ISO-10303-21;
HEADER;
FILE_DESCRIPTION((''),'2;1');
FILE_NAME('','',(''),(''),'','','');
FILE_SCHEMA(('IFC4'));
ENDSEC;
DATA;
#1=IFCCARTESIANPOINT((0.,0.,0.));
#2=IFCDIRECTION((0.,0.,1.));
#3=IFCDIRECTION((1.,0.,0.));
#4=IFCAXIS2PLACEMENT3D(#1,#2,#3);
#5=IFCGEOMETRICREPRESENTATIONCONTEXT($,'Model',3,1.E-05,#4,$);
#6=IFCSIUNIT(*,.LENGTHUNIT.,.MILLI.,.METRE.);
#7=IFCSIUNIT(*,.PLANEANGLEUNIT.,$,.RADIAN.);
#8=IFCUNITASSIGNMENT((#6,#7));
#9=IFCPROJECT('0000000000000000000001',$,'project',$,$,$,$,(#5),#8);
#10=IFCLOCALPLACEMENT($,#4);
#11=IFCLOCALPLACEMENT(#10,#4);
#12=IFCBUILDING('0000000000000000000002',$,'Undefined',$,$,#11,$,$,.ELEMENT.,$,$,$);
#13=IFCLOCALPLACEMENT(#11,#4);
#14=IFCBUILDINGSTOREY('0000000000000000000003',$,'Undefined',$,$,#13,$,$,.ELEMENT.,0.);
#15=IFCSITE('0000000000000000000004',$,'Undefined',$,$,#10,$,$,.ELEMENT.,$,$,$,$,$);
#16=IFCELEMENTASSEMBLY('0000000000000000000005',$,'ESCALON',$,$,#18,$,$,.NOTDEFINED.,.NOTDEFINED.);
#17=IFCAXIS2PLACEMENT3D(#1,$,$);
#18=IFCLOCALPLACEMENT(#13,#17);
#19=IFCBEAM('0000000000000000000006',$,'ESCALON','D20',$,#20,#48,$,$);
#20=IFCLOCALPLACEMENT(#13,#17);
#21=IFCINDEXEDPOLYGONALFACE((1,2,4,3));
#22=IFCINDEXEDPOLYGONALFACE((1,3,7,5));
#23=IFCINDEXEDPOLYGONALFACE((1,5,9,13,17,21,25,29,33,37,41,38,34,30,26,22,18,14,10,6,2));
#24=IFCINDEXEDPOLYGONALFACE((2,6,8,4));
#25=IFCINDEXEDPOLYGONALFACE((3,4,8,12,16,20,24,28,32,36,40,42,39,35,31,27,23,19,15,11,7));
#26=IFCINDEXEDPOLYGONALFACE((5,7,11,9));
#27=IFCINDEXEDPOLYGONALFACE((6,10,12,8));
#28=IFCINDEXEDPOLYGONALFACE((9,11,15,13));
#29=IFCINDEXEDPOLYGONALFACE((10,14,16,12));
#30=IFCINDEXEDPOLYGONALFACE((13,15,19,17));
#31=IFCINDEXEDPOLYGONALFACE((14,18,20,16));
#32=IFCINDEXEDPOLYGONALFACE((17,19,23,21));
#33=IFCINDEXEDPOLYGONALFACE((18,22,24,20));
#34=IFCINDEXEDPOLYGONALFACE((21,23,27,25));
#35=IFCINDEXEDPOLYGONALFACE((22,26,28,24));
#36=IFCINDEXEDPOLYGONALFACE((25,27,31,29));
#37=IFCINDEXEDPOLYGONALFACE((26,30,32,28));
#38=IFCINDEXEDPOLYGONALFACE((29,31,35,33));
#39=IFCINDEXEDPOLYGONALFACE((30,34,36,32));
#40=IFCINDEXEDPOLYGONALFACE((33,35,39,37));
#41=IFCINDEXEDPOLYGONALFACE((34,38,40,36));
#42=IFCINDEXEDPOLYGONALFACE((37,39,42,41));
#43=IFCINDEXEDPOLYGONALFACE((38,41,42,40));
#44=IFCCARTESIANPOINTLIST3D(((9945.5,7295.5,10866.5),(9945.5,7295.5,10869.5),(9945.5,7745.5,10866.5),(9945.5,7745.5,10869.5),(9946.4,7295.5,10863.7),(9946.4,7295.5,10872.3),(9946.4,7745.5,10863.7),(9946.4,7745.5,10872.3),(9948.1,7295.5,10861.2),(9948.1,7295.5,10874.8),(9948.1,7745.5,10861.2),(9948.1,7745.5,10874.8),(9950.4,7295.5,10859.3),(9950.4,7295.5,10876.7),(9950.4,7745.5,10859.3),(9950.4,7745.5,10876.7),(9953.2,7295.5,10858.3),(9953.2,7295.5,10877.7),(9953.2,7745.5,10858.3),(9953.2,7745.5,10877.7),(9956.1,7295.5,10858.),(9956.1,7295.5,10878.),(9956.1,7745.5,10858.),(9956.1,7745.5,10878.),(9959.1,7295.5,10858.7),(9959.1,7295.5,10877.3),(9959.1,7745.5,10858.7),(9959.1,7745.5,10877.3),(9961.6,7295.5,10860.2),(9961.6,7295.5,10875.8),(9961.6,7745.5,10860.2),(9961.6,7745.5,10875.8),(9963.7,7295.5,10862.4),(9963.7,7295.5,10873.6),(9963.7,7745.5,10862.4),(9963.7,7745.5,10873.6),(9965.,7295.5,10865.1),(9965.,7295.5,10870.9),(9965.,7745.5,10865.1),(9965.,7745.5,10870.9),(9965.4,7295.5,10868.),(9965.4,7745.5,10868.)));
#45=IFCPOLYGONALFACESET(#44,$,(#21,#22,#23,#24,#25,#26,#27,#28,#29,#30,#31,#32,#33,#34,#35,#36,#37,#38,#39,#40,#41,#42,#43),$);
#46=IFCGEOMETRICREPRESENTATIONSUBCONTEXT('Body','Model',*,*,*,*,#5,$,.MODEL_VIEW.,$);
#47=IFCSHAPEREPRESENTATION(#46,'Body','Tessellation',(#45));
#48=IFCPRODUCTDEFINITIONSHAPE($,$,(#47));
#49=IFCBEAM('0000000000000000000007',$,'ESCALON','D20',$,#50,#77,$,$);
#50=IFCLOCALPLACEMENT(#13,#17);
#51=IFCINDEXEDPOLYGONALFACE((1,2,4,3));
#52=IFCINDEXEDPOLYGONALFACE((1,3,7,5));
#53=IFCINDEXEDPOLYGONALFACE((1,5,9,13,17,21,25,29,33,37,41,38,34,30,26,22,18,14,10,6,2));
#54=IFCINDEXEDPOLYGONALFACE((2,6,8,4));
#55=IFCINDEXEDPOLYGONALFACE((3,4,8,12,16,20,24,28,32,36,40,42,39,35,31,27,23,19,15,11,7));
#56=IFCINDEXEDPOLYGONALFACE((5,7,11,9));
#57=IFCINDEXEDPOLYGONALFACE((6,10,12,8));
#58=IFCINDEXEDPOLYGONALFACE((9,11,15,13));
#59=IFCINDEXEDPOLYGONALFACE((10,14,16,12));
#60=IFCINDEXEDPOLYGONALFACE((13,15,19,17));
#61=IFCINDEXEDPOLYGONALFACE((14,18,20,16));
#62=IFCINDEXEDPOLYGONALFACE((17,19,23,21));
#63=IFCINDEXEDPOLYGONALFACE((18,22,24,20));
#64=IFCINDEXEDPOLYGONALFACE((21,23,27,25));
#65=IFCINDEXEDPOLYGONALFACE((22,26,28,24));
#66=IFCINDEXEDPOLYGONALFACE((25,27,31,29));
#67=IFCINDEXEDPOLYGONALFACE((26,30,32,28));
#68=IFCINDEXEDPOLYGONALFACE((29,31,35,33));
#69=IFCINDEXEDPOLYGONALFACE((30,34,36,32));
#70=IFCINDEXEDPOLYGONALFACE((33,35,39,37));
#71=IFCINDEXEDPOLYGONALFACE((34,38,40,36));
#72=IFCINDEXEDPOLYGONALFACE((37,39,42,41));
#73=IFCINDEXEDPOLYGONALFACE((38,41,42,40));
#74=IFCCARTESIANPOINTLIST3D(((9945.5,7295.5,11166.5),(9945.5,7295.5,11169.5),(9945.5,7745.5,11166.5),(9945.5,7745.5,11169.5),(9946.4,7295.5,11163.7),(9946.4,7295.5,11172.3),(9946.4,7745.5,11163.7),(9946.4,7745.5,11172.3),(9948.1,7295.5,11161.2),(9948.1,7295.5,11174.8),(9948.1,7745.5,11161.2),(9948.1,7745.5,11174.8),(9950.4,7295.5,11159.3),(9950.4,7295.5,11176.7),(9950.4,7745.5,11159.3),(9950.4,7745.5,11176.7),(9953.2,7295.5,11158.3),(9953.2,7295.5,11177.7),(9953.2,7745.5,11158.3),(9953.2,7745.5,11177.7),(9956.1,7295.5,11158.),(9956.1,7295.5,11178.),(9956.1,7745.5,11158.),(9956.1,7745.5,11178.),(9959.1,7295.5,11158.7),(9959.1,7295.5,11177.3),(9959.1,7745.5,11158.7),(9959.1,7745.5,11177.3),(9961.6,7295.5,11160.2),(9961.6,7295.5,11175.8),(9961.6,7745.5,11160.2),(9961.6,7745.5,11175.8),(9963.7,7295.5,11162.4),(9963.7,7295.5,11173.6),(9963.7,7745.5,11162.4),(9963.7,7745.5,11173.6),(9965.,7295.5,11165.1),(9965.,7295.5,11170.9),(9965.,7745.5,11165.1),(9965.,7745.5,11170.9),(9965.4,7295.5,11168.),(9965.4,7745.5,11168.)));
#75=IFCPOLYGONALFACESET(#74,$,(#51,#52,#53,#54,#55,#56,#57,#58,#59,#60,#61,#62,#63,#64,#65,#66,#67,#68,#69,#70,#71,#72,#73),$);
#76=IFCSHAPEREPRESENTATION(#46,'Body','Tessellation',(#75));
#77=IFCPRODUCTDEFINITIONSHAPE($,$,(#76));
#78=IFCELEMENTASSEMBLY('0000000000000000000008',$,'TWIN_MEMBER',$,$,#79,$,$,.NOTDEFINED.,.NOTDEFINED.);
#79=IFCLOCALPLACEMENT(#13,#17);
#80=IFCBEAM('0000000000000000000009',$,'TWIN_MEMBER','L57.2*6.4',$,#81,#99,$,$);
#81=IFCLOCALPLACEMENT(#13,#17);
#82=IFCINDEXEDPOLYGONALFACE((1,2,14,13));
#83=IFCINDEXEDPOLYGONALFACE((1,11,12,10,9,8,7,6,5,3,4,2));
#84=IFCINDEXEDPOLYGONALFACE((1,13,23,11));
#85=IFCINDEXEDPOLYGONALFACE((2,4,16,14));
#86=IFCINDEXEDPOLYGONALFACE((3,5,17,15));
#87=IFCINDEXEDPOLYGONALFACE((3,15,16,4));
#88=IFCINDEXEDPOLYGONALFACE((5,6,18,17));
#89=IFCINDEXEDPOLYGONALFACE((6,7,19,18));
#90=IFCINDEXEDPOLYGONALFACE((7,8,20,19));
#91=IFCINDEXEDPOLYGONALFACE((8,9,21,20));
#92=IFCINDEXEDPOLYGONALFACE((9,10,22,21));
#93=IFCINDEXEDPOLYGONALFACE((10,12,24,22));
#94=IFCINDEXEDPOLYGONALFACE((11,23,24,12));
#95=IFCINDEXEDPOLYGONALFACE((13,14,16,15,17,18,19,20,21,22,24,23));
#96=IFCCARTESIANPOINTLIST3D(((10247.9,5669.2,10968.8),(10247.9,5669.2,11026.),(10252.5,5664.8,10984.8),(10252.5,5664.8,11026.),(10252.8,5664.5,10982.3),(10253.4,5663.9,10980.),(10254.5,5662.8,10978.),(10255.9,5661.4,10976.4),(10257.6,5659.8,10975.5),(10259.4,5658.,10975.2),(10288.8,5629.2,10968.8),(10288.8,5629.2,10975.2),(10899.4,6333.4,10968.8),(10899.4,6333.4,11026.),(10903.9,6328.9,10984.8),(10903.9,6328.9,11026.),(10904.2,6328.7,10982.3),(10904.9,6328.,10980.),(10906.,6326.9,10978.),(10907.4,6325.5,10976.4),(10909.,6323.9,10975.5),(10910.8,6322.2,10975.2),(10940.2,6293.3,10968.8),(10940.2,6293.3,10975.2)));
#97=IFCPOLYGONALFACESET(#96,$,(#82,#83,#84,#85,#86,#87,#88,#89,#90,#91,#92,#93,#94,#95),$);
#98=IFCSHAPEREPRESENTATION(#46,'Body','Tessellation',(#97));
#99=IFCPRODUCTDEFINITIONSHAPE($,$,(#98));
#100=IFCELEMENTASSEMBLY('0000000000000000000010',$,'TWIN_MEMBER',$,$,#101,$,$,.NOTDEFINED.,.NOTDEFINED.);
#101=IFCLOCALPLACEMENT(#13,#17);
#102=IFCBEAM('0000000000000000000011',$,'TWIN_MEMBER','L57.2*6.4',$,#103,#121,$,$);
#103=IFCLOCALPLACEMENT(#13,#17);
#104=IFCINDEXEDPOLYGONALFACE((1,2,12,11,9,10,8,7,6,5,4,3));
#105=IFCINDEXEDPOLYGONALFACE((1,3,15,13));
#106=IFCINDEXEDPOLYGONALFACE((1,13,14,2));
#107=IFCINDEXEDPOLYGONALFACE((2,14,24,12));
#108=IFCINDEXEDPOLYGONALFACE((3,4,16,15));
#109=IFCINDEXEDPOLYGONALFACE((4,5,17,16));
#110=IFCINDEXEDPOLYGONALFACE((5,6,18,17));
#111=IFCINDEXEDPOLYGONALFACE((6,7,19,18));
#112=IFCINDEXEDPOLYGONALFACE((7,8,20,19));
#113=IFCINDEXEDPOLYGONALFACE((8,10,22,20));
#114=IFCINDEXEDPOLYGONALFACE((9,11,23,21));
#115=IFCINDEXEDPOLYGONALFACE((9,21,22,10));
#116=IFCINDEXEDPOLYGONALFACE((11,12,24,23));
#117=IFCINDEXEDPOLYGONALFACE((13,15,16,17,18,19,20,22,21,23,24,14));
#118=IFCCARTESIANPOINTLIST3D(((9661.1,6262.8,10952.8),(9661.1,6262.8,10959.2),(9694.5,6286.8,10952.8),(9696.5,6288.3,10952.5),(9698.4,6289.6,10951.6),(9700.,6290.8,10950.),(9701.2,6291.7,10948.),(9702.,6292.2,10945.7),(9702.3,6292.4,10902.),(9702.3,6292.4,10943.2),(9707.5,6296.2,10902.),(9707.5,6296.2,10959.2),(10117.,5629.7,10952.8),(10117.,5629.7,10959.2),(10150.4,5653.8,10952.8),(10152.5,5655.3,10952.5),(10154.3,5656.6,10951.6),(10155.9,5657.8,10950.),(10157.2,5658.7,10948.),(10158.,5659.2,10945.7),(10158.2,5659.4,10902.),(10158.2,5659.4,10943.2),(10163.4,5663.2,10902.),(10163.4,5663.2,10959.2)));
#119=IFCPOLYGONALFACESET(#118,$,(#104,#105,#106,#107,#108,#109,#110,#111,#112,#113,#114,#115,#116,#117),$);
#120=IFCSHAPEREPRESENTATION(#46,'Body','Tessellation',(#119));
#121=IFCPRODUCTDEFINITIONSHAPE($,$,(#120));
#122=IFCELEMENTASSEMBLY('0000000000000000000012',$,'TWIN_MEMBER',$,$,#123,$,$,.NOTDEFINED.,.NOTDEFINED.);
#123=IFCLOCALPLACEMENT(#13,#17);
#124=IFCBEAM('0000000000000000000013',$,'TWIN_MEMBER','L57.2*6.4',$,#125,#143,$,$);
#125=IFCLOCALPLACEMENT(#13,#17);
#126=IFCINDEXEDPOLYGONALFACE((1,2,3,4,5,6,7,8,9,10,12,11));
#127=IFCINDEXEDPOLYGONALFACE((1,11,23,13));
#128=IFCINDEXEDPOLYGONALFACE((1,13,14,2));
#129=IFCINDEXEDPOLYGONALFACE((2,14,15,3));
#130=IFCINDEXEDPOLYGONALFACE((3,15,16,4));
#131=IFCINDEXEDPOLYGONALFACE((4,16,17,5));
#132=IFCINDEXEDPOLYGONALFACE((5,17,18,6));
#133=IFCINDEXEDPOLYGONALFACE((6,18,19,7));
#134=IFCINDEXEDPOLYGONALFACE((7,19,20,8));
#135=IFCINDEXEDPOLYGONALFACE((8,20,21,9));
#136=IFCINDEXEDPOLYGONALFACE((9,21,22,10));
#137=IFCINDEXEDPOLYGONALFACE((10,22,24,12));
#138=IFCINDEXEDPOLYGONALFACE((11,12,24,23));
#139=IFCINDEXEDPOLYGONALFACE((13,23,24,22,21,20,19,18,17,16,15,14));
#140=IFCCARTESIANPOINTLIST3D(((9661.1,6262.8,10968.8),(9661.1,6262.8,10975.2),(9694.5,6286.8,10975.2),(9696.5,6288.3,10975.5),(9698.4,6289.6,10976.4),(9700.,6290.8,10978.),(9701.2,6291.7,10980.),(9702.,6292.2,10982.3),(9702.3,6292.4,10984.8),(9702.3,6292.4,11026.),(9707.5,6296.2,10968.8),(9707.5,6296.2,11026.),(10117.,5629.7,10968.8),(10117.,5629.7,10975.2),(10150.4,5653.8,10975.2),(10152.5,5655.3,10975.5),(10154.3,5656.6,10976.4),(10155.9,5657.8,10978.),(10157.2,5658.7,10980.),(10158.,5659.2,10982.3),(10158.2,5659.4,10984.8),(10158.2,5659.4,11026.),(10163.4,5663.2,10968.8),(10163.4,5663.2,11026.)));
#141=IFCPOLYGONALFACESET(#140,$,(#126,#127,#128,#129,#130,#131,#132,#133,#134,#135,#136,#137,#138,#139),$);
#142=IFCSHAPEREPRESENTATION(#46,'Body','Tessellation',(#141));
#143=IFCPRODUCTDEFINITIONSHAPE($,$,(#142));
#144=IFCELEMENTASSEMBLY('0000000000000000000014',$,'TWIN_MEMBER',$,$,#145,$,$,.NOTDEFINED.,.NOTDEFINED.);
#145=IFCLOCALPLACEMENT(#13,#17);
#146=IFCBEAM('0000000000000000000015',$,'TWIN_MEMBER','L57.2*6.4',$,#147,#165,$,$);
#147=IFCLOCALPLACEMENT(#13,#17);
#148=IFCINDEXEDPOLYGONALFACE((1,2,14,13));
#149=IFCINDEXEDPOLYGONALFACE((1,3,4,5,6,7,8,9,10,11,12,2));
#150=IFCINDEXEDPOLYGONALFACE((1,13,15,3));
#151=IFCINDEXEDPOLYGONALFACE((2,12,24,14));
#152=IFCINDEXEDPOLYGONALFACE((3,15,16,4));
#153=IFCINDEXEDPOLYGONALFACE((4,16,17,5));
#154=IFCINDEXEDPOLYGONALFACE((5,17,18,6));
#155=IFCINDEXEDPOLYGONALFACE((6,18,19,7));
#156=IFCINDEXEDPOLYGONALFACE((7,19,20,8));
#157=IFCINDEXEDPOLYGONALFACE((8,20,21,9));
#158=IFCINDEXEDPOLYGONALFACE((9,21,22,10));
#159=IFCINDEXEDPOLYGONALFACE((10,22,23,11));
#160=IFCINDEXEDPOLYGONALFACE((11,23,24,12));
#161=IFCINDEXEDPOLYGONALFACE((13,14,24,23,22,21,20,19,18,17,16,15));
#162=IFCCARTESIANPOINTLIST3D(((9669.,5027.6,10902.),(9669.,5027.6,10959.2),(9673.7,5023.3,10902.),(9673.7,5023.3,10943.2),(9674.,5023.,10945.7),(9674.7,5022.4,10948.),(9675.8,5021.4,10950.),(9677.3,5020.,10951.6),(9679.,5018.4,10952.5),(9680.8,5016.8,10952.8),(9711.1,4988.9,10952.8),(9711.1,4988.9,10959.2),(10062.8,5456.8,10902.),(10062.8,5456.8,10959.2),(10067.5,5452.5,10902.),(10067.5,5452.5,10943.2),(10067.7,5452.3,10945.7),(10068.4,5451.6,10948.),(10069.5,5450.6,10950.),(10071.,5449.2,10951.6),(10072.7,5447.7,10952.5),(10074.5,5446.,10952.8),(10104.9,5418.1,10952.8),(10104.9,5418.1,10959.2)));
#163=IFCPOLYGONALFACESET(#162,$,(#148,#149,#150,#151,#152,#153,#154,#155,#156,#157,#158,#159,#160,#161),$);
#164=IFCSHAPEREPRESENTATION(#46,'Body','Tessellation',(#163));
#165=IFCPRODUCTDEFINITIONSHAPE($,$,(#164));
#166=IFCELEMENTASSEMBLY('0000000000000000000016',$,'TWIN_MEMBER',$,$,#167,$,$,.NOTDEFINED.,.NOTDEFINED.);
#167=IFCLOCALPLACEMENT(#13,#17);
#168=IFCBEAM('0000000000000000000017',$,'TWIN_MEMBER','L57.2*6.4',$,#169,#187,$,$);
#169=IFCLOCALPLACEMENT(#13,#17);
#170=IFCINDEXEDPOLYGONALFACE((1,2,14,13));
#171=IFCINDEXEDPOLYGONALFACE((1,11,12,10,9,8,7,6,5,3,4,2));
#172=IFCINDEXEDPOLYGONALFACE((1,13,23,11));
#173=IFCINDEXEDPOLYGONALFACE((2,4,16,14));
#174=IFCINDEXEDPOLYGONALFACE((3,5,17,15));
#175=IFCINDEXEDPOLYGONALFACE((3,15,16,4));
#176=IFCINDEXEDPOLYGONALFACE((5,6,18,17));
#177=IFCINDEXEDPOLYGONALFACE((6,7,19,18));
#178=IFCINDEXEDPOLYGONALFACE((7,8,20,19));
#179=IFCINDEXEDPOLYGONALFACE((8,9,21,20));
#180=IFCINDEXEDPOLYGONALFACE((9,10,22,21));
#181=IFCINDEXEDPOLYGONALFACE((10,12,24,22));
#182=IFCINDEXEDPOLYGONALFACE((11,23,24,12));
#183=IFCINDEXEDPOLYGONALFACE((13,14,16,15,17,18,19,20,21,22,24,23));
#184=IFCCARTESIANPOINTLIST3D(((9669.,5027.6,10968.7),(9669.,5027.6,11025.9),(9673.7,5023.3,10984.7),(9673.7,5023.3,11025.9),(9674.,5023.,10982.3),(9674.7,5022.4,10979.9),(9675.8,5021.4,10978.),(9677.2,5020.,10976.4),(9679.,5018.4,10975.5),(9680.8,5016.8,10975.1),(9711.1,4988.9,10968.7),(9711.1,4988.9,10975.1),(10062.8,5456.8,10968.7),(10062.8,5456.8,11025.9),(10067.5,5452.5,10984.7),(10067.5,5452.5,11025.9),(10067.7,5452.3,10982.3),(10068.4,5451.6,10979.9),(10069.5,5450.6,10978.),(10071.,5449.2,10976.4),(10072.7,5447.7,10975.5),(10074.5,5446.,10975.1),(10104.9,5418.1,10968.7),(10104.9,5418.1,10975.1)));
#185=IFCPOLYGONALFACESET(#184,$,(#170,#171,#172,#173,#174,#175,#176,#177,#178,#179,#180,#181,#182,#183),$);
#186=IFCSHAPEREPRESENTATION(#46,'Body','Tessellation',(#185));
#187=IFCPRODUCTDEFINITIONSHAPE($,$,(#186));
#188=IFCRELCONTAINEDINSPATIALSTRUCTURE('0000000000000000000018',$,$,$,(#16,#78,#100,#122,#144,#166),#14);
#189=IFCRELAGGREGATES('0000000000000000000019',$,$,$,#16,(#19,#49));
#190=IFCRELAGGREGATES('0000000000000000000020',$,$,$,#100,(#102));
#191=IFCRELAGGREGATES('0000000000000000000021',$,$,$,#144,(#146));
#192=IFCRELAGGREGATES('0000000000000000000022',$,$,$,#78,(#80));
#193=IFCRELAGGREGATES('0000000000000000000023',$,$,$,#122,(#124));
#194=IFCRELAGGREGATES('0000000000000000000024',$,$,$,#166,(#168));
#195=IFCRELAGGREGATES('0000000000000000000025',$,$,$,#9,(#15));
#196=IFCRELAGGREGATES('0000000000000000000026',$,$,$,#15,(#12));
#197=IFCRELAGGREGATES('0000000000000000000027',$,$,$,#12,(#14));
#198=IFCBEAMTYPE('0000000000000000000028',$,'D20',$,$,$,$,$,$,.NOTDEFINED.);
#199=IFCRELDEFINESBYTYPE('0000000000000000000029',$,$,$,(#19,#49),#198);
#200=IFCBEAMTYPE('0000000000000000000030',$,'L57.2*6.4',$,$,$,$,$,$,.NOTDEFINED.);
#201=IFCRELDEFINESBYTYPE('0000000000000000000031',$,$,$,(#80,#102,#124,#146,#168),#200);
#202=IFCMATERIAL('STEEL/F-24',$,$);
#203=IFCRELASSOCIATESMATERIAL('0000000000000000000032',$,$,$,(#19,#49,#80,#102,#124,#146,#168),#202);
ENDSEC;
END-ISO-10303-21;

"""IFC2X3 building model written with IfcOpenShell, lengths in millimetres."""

from ifc_helpers import new_model, si_unit, frame, origin_with_axes, origin_2d_with_axis, place, context, subcontext, project, spatial, circle, l_section, extrude, material, type_object, element, aggregate, save


model = new_model("IFC2X3")

# Units and contexts
model_context = context("Model", 3, precision=1e-05, world=origin_with_axes())
body_context = subcontext(model_context, "Body", "Model", "MODEL_VIEW")
ifc_project = project(units=[si_unit("LENGTHUNIT", "METRE", prefix="MILLI"), si_unit("PLANEANGLEUNIT", "RADIAN")], contexts=[model_context])

# Site, building, storey
site_placement = place(None, origin_with_axes())
site = spatial("IfcSite", under=ifc_project, at=site_placement, Name="Undefined", CompositionType="ELEMENT")
building_placement = place(site_placement, origin_with_axes())
building = spatial("IfcBuilding", under=site, at=building_placement, Name="Undefined", CompositionType="ELEMENT")
storey_placement = place(building_placement, origin_with_axes())
storey = spatial("IfcBuildingStorey", under=building, at=storey_placement, Name="Undefined", CompositionType="ELEMENT", Elevation=0.0)

# Element assembly, beams
assembly_1_placement = place(storey_placement, origin_with_axes())
assembly_1 = element("IfcElementAssembly", 1, at=assembly_1_placement, inside=storey, Name="ESCALON", AssemblyPlace="NOTDEFINED", PredefinedType="NOTDEFINED")
ifc_material_1 = material(Name="STEEL/F-24")
beam_type_1 = type_object("IfcBeamType", Name="D20", PredefinedType="NOTDEFINED")
beam_1_placement = place(assembly_1_placement, frame((9955.4, 7295.5, 10868.0), z_axis=(0.0, 0.0, 1.0), x_axis=(0.0, 1.0, 0.0)))
beam_1 = element("IfcBeam", 2, at=beam_1_placement, type_object=beam_type_1, material=ifc_material_1, Name="ESCALON", Description="D20", context=body_context, shape_type="SweptSolid", body=[
    extrude(circle(Radius=10.0, at=origin_2d_with_axis()), frame((450.0, 0.0, 0.0), z_axis=(-1.0, 0.0, 0.0), x_axis=(0.0, -1.0, 0.0)), (0.0, 0.0, 1.0), 450.0),
])
beam_2_placement = place(assembly_1_placement, frame((9955.4, 7295.5, 11168.0), z_axis=(0.0, 0.0, 1.0), x_axis=(0.0, 1.0, 0.0)))
beam_2 = element("IfcBeam", 3, at=beam_2_placement, type_object=beam_type_1, material=ifc_material_1, Name="ESCALON", Description="D20", context=body_context, shape_type="SweptSolid", body=[
    extrude(circle(Radius=10.0, at=origin_2d_with_axis()), frame((450.0, 0.0, 0.0), z_axis=(-1.0, 0.0, 0.0), x_axis=(0.0, -1.0, 0.0)), (0.0, 0.0, 1.0), 450.0),
])
aggregate(assembly_1, [beam_1, beam_2])

# Element assemblies, beams
assembly_2_placement = place(storey_placement, origin_with_axes())
assembly_2 = element("IfcElementAssembly", 4, at=assembly_2_placement, inside=storey, Name="TWIN_MEMBER", AssemblyPlace="NOTDEFINED", PredefinedType="NOTDEFINED")
beam_type_2 = type_object("IfcBeamType", Name="L57.2*6.4", PredefinedType="NOTDEFINED")
beam_3_placement = place(assembly_2_placement, frame((10268.4, 5649.2, 10997.4), z_axis=(0.0, 0.0, 1.0), x_axis=(0.700239, 0.713908, 0.0)))
beam_3 = element("IfcBeam", 5, at=beam_3_placement, type_object=beam_type_2, material=ifc_material_1, Name="TWIN_MEMBER", Description="L57.2*6.4", context=body_context, shape_type="SweptSolid", body=[
    extrude(l_section(Depth=57.2, Width=57.2, Thickness=6.4, FilletRadius=9.6, at=origin_2d_with_axis()), frame((930.3, 0.0, 0.0), z_axis=(-1.0, 0.0, 0.0), x_axis=(0.0, -1.0, 0.0)), (0.0, 0.0, 1.0), 930.3),
])
assembly_3_placement = place(storey_placement, origin_with_axes())
assembly_3 = element("IfcElementAssembly", 6, at=assembly_3_placement, inside=storey, Name="TWIN_MEMBER", AssemblyPlace="NOTDEFINED", PredefinedType="NOTDEFINED")
beam_4_placement = place(assembly_3_placement, frame((10140.2, 5646.4, 10930.6), z_axis=(0.0, 0.0, -1.0), x_axis=(-0.584443, 0.811435, 0.0)))
beam_4 = element("IfcBeam", 7, at=beam_4_placement, type_object=beam_type_2, material=ifc_material_1, Name="TWIN_MEMBER", Description="L57.2*6.4", context=body_context, shape_type="SweptSolid", body=[
    extrude(l_section(Depth=57.2, Width=57.2, Thickness=6.4, FilletRadius=9.6, at=origin_2d_with_axis()), frame((780.1, 0.0, 0.0), z_axis=(-1.0, 0.0, 0.0), x_axis=(0.0, -1.0, 0.0)), (0.0, 0.0, 1.0), 780.1),
])
aggregate(assembly_3, [beam_4])
assembly_4_placement = place(storey_placement, origin_with_axes())
assembly_4 = element("IfcElementAssembly", 8, at=assembly_4_placement, inside=storey, Name="TWIN_MEMBER", AssemblyPlace="NOTDEFINED", PredefinedType="NOTDEFINED")
beam_5_placement = place(assembly_4_placement, frame((9684.3, 6279.5, 10997.4), z_axis=(0.0, 0.0, 1.0), x_axis=(0.584443, -0.811435, 0.0)))
beam_5 = element("IfcBeam", 9, at=beam_5_placement, type_object=beam_type_2, material=ifc_material_1, Name="TWIN_MEMBER", Description="L57.2*6.4", context=body_context, shape_type="SweptSolid", body=[
    extrude(l_section(Depth=57.2, Width=57.2, Thickness=6.4, FilletRadius=9.6, at=origin_2d_with_axis()), frame((780.1, 0.0, 0.0), z_axis=(-1.0, 0.0, 0.0), x_axis=(0.0, -1.0, 0.0)), (0.0, 0.0, 1.0), 780.1),
])
assembly_5_placement = place(storey_placement, origin_with_axes())
assembly_5 = element("IfcElementAssembly", 10, at=assembly_5_placement, inside=storey, Name="TWIN_MEMBER", AssemblyPlace="NOTDEFINED", PredefinedType="NOTDEFINED")
beam_6_placement = place(assembly_5_placement, frame((10083.8, 5437.5, 10930.6), z_axis=(0.0, 0.0, -1.0), x_axis=(-0.67601, -0.736893, 0.0)))
beam_6 = element("IfcBeam", 11, at=beam_6_placement, type_object=beam_type_2, material=ifc_material_1, Name="TWIN_MEMBER", Description="L57.2*6.4", context=body_context, shape_type="SweptSolid", body=[
    extrude(l_section(Depth=57.2, Width=57.2, Thickness=6.4, FilletRadius=9.6, at=origin_2d_with_axis()), frame((582.5, 0.0, 0.0), z_axis=(-1.0, 0.0, 0.0), x_axis=(0.0, -1.0, 0.0)), (0.0, 0.0, 1.0), 582.5),
])
aggregate(assembly_5, [beam_6])
assembly_6_placement = place(storey_placement, origin_with_axes())
assembly_6 = element("IfcElementAssembly", 12, at=assembly_6_placement, inside=storey, Name="TWIN_MEMBER", AssemblyPlace="NOTDEFINED", PredefinedType="NOTDEFINED")
beam_7_placement = place(assembly_6_placement, frame((9690.1, 5008.2, 10997.3), z_axis=(0.0, 0.0, 1.0), x_axis=(0.67601, 0.736893, 0.0)))
beam_7 = element("IfcBeam", 13, at=beam_7_placement, type_object=beam_type_2, material=ifc_material_1, Name="TWIN_MEMBER", Description="L57.2*6.4", context=body_context, shape_type="SweptSolid", body=[
    extrude(l_section(Depth=57.2, Width=57.2, Thickness=6.4, FilletRadius=9.6, at=origin_2d_with_axis()), frame((582.5, 0.0, 0.0), z_axis=(-1.0, 0.0, 0.0), x_axis=(0.0, -1.0, 0.0)), (0.0, 0.0, 1.0), 582.5),
])

aggregate(assembly_2, [beam_3])
aggregate(assembly_4, [beam_5])
aggregate(assembly_6, [beam_7])

save(model, "model.ifc")
